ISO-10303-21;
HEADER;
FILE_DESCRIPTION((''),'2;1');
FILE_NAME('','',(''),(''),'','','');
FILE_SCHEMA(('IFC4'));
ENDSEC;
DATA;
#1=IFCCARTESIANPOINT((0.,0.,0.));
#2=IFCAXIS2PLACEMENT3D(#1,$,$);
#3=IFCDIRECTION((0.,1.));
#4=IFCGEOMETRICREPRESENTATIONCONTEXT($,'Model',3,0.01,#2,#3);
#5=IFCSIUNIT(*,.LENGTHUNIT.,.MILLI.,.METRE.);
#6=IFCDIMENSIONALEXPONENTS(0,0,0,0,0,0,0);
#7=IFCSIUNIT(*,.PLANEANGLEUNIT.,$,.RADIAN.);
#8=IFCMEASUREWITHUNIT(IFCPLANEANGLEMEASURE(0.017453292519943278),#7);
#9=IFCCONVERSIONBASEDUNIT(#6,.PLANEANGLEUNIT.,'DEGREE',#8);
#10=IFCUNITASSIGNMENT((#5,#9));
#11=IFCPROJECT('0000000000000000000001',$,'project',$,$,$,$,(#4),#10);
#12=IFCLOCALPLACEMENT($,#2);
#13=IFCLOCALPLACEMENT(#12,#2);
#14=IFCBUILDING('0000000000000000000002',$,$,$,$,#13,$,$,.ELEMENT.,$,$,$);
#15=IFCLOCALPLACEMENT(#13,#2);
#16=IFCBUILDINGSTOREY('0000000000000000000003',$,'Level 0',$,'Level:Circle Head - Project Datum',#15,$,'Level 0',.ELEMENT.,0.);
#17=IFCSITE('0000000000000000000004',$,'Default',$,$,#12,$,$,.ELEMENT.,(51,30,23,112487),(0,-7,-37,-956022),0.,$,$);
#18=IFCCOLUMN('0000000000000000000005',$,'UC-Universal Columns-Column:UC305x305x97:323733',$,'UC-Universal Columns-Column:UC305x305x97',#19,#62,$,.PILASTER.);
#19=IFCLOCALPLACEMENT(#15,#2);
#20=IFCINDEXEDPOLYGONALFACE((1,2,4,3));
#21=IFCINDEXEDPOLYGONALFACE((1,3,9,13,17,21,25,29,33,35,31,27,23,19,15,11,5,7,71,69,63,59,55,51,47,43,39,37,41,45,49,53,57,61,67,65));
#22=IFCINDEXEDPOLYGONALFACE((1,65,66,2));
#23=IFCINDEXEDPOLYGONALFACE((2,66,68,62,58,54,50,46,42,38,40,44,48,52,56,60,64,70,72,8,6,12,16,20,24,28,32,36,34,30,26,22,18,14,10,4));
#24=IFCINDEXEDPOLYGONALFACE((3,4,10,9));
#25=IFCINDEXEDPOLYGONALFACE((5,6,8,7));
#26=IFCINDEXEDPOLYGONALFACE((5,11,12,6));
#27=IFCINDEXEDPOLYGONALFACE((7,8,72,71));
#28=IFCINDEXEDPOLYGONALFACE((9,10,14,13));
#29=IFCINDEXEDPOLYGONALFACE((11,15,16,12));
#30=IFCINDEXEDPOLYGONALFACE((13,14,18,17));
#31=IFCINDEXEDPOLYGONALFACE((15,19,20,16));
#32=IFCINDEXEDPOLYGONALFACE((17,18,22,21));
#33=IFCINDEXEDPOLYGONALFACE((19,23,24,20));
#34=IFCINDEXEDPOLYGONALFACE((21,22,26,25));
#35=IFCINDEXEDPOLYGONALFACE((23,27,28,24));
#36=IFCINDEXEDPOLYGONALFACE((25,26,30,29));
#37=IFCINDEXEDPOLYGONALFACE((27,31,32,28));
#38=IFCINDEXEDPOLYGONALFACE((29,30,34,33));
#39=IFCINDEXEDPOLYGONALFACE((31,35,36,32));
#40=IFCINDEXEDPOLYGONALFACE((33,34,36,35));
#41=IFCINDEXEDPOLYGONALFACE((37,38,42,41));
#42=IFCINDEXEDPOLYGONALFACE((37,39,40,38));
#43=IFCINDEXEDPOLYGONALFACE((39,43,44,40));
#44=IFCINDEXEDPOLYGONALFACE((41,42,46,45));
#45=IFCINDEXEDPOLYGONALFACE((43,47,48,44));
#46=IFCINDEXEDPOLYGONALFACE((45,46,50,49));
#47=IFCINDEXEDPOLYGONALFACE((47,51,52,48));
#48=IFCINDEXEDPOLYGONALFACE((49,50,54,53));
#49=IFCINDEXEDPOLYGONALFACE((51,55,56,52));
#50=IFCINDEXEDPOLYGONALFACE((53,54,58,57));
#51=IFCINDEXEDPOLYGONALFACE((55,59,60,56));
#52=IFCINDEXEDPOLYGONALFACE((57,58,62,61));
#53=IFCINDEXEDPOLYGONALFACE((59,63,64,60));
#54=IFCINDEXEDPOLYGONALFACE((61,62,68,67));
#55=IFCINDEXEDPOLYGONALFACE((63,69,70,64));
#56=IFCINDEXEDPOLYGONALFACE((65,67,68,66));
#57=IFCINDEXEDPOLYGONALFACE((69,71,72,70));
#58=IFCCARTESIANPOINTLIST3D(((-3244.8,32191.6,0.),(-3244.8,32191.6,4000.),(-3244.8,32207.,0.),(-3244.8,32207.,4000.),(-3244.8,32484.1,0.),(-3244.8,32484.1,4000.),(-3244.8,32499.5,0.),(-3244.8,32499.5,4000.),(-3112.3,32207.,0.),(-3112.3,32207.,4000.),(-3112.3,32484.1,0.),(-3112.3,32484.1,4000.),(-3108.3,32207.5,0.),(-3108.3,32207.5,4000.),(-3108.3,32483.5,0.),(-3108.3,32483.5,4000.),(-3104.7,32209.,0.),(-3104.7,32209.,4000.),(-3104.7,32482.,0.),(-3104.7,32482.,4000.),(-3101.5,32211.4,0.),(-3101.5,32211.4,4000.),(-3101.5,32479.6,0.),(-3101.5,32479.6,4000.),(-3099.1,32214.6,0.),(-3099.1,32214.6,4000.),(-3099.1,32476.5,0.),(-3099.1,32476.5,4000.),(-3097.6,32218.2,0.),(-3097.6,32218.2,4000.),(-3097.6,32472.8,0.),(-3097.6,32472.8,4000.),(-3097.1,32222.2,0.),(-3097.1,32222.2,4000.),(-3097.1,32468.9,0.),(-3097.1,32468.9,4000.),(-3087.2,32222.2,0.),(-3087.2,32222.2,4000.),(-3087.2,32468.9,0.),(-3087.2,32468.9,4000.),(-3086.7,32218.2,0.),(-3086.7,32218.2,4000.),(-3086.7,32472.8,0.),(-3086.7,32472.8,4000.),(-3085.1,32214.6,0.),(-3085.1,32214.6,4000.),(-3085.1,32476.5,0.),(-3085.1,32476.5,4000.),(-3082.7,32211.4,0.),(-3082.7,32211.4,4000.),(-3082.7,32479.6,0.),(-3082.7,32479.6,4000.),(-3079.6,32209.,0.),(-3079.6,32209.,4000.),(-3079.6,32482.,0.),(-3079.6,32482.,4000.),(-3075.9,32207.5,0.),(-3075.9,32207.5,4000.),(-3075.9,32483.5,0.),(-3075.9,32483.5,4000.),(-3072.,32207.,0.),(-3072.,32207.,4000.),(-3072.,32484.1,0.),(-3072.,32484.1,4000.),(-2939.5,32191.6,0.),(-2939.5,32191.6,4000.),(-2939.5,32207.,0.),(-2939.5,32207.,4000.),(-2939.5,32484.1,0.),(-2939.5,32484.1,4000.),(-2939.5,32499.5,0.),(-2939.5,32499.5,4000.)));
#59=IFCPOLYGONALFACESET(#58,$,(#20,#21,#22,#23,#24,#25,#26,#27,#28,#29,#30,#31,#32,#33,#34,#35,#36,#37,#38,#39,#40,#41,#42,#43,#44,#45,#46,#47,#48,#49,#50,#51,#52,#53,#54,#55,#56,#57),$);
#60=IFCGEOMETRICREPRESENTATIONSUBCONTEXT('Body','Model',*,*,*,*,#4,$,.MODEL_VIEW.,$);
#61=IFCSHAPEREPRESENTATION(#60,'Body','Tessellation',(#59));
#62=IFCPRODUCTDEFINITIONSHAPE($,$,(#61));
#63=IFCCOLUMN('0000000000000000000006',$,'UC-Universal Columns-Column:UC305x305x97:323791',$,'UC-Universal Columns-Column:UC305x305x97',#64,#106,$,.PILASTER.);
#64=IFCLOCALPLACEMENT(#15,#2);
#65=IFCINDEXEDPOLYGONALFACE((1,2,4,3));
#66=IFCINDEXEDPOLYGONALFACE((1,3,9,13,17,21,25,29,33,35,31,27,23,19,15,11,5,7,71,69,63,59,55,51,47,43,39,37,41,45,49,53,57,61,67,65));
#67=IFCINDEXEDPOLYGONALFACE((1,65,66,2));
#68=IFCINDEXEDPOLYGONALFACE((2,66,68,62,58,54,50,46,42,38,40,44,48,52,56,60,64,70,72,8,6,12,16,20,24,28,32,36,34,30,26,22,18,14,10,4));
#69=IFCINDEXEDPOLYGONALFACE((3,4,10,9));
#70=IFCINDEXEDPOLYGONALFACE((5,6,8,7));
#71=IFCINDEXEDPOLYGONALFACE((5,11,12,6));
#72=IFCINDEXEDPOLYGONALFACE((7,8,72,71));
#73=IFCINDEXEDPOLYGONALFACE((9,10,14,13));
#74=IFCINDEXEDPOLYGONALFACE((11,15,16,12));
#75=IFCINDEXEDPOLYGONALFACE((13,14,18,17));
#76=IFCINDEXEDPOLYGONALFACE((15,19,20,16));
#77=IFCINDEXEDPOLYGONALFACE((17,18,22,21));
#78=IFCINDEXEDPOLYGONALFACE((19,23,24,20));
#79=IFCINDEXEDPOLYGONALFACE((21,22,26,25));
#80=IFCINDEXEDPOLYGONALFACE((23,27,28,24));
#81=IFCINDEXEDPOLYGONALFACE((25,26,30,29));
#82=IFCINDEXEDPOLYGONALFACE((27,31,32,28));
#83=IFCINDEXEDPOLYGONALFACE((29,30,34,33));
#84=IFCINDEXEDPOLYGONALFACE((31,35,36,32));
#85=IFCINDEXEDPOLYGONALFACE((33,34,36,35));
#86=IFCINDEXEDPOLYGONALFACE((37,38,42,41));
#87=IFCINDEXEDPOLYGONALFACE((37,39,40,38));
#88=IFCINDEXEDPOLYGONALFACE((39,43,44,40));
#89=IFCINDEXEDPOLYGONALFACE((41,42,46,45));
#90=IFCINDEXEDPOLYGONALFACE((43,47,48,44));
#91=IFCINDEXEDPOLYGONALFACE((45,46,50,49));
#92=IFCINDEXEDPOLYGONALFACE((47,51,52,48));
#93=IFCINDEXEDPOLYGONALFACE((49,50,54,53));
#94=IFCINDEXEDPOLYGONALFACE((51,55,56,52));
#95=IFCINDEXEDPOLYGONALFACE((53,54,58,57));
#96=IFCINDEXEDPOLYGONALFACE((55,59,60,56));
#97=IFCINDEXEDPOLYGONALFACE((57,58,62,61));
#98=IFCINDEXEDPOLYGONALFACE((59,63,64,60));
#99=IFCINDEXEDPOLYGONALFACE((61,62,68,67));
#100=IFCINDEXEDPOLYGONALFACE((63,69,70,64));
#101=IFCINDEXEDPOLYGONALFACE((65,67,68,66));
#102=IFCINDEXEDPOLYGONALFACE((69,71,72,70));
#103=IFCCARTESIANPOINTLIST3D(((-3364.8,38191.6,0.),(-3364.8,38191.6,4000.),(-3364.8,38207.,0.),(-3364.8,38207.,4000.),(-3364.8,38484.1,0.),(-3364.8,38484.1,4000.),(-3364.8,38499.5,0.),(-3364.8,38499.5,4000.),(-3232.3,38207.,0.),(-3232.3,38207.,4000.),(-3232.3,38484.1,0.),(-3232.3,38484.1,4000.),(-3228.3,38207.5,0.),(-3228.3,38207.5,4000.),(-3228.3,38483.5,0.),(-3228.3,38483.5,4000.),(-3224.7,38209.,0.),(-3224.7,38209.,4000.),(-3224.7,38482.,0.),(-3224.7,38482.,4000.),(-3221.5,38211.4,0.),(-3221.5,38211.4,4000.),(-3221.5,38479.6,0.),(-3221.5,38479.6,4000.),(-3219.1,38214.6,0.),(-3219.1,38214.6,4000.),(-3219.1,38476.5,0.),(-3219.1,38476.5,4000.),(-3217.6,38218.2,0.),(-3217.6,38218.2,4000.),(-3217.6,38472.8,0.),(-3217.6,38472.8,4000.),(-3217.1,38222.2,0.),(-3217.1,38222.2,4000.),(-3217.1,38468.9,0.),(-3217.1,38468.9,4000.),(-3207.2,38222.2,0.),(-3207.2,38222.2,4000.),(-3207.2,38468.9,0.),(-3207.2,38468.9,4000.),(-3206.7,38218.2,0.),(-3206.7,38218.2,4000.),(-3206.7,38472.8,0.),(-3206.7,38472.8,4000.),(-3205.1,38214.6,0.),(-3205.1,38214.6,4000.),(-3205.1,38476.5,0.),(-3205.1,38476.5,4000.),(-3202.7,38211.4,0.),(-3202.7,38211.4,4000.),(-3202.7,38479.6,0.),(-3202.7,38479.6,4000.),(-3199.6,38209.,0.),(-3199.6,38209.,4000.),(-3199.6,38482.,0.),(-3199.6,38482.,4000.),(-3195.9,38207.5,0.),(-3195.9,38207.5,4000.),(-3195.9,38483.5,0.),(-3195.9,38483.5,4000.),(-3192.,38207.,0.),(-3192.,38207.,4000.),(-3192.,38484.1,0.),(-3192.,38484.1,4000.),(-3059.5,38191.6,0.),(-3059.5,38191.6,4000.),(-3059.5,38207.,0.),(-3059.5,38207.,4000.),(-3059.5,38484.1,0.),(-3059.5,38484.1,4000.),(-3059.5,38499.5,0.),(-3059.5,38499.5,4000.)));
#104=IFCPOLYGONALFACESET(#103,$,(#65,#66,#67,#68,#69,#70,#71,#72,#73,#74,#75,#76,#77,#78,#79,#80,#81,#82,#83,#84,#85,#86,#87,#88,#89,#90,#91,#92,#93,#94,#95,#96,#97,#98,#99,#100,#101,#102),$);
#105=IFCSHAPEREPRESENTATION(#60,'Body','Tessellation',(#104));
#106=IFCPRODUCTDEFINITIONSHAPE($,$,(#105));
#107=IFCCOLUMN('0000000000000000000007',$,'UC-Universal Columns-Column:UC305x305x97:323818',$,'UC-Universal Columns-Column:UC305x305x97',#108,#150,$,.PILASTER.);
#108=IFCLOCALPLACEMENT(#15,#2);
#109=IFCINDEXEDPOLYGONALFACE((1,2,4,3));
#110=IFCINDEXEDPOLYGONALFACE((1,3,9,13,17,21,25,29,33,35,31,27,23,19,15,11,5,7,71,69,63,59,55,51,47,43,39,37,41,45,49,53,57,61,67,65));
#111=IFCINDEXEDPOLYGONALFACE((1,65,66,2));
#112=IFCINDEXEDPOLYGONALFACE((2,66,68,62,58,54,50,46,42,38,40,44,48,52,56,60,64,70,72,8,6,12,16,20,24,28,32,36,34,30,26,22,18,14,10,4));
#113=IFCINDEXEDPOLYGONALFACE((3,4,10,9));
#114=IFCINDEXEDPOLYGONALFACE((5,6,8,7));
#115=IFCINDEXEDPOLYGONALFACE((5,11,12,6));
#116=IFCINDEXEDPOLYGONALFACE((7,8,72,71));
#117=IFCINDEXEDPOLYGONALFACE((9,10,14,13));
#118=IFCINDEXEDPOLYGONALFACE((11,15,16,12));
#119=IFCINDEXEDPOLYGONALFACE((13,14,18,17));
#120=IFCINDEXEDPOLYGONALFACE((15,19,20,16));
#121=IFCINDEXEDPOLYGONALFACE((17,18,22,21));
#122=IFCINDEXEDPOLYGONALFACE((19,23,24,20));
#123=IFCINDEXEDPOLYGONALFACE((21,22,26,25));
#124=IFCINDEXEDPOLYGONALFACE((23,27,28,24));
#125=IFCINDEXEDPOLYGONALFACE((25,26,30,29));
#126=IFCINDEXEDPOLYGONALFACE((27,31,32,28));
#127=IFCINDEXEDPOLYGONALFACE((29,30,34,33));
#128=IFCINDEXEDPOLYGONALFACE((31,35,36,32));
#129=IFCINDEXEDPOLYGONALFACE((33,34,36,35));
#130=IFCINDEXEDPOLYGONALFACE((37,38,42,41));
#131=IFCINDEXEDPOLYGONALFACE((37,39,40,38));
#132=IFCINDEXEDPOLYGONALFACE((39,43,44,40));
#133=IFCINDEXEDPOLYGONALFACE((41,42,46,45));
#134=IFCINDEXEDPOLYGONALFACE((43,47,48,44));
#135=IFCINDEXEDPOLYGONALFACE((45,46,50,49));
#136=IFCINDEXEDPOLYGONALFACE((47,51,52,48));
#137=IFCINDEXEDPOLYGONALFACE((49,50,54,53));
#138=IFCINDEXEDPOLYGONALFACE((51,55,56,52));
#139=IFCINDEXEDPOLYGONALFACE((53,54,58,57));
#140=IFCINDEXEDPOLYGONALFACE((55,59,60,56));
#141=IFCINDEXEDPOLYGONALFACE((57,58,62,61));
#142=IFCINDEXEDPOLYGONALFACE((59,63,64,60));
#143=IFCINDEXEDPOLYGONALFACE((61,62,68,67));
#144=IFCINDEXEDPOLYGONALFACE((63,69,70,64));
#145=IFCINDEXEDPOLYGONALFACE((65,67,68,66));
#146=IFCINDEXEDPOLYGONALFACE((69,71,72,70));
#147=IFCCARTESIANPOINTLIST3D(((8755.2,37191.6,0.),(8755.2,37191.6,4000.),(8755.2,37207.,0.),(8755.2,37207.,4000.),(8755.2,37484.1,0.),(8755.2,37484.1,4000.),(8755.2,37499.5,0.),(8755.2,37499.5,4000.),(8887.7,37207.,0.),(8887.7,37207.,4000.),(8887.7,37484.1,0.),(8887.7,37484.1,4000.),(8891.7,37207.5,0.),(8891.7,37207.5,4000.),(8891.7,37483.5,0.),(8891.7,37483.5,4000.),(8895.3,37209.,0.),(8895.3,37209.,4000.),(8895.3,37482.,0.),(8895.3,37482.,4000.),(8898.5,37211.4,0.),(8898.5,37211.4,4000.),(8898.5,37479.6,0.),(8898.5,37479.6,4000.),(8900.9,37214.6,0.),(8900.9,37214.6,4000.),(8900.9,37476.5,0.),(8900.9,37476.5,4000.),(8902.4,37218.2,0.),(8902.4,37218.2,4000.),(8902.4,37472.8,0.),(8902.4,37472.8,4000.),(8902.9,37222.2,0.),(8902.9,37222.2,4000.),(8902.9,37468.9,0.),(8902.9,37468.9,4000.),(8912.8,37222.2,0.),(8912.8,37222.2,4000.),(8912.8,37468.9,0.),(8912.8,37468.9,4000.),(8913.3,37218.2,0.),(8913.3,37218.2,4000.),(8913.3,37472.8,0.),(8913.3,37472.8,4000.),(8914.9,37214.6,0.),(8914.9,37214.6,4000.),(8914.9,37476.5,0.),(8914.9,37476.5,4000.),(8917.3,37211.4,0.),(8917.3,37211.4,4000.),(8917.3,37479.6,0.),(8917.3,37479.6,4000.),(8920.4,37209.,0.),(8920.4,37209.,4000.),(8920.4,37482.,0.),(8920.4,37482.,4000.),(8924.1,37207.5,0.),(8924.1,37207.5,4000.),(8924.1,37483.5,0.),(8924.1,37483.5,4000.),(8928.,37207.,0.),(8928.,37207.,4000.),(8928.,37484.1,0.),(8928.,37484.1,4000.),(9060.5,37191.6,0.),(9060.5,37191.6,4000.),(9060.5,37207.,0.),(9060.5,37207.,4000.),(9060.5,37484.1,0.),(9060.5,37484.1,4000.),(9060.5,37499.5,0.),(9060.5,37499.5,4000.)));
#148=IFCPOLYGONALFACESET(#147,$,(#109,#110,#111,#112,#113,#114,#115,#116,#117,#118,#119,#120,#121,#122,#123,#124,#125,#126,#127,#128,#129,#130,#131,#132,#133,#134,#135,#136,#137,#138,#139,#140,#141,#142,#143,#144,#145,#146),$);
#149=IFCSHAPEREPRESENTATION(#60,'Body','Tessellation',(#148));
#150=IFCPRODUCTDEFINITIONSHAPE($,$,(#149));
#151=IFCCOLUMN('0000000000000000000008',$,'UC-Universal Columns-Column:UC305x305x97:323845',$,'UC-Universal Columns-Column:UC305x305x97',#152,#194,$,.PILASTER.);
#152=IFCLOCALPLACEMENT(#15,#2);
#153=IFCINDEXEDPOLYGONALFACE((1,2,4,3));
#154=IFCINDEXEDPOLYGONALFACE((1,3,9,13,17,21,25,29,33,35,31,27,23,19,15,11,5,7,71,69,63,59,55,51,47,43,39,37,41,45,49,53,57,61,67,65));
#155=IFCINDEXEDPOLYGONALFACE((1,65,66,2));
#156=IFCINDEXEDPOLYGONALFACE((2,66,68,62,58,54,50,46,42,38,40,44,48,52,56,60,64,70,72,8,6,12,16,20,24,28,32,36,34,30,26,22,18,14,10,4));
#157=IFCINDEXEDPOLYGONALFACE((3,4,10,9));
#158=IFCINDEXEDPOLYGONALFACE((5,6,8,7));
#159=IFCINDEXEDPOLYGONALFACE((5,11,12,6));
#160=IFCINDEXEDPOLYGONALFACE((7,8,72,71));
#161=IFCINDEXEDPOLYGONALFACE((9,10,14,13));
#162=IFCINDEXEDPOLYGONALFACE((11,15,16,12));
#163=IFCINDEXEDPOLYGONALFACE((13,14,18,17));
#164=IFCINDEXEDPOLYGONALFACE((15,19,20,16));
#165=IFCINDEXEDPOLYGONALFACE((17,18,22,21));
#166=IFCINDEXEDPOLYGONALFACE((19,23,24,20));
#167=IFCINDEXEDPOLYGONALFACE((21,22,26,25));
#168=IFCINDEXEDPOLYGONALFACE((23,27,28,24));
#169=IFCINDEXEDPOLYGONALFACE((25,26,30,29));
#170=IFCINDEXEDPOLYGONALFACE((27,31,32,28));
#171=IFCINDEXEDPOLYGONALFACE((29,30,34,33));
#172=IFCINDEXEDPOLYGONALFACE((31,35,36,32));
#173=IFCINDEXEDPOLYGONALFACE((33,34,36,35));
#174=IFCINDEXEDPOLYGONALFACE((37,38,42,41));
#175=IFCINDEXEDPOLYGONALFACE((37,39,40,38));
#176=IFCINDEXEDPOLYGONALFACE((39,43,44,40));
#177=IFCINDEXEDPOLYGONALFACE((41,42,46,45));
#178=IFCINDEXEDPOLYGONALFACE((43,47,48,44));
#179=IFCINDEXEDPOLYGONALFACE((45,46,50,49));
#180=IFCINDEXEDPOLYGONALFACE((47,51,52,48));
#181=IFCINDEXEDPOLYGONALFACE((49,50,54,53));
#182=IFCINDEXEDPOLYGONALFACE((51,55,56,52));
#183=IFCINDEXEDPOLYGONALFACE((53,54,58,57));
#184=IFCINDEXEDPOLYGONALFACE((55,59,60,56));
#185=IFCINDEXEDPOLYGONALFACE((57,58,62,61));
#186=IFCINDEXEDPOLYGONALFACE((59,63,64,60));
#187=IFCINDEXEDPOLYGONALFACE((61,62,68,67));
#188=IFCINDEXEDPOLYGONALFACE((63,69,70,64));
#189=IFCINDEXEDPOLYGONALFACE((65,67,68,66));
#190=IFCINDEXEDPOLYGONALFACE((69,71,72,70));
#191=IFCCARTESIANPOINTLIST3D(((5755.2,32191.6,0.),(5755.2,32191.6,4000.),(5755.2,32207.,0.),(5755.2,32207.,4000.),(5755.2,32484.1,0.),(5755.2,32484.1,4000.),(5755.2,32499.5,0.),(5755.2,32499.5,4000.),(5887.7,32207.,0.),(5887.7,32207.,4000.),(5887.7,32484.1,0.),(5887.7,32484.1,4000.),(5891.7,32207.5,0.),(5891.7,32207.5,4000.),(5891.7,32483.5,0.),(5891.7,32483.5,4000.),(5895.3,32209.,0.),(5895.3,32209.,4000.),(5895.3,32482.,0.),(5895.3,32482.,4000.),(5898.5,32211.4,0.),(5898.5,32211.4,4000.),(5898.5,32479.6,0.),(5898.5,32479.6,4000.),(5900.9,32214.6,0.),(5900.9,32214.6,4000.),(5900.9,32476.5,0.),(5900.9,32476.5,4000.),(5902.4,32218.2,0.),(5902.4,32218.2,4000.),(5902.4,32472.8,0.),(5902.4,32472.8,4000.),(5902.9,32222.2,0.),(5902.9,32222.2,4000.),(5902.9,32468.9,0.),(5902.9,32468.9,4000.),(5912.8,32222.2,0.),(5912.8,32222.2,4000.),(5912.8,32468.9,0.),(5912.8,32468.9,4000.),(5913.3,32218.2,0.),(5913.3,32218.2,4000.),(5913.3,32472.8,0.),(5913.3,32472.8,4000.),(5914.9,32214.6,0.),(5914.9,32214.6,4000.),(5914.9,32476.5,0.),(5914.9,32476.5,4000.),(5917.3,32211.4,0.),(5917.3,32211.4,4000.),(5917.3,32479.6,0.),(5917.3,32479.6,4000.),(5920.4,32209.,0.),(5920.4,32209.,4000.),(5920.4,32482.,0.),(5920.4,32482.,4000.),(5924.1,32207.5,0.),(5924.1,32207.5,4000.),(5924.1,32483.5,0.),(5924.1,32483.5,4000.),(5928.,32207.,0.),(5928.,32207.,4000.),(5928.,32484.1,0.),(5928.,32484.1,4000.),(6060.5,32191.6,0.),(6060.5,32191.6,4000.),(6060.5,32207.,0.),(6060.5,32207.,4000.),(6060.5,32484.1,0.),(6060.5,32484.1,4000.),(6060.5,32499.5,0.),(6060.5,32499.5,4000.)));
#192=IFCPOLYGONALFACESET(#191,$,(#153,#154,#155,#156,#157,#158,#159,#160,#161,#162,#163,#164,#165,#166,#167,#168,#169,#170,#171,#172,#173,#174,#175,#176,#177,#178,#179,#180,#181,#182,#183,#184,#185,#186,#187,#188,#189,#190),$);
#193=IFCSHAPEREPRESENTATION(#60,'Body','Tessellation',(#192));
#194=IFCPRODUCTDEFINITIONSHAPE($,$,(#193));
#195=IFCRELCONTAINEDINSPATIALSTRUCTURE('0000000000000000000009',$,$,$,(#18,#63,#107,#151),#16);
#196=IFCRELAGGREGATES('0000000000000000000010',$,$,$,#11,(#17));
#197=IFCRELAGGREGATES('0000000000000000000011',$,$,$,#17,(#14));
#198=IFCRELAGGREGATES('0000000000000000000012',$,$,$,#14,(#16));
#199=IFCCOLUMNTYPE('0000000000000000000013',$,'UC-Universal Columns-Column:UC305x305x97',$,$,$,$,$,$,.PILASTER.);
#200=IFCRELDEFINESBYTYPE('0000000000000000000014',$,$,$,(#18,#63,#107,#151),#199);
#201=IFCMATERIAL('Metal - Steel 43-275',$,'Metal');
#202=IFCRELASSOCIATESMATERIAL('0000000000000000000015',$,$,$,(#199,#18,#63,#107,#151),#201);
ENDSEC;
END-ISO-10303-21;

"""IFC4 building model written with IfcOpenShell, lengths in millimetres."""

from ifc_helpers import new_model, entity, si_unit, converted_unit, direction, frame, origin, place, context, subcontext, project, spatial, line, arc, indexed_curve, outline, extrude, source, transform, mapped, material, type_object, type_shapes, element, save


model = new_model("IFC4")

# Units and contexts
model_context = context("Model", 3, precision=0.01, world=origin(), true_north=direction((0.0, 1.0)))
body_context = subcontext(model_context, "Body", "Model", "MODEL_VIEW")
ifc_project = project(units=[si_unit("LENGTHUNIT", "METRE", prefix="MILLI"), converted_unit("PLANEANGLEUNIT", "DEGREE", entity("IfcPlaneAngleMeasure", 0.017453292519943278), si_unit("PLANEANGLEUNIT", "RADIAN"), dimensions=[0, 0, 0, 0, 0, 0, 0])], contexts=[model_context])

# Site, building, storey
site_placement = place(None, origin())
site = spatial("IfcSite", under=ifc_project, at=site_placement, Name="Default", CompositionType="ELEMENT", RefLatitude=(51, 30, 23, 112487), RefLongitude=(0, -7, -37, -956022), RefElevation=0.0)
building_placement = place(site_placement, origin())
building = spatial("IfcBuilding", under=site, at=building_placement, CompositionType="ELEMENT")
storey_placement = place(building_placement, origin())
storey = spatial("IfcBuildingStorey", under=building, at=storey_placement, Name="Level 0", ObjectType="Level:Circle Head - Project Datum", LongName="Level 0", CompositionType="ELEMENT", Elevation=0.0)

# Columns
ifc_material_1 = material(Name="Metal - Steel 43-275", Category="Metal")
column_type = type_object("IfcColumnType", Name="UC-Universal Columns-Column:UC305x305x97", PredefinedType="PILASTER", material=ifc_material_1)
shared_shape_1 = source(origin(), body_context, "Body", "SweptSolid", [
    extrude(outline(indexed_curve([(-152.6, -153.9), (152.6, -153.9), (152.6, -138.5), (20.2, -138.5), (9.4, -134.1), (4.9, -123.4), (4.9, 123.3), (9.4, 134.1), (20.1, 138.5), (152.6, 138.5), (152.6, 153.9), (-152.6, 153.9), (-152.6, 138.5), (-20.2, 138.6), (-9.4, 134.1), (-5.0, 123.4), (-5.0, -123.3), (-9.4, -134.1), (-20.2, -138.5), (-152.6, -138.5)], segments=[line(1, 2, 3, 4), arc(4, 5, 6), line(6, 7), arc(7, 8, 9), line(9, 10, 11, 12, 13, 14), arc(14, 15, 16), line(16, 17), arc(17, 18, 19), line(19, 20, 1)], self_intersect=False)), frame((0.0, 0.0, 0.0), z_axis=(0.0, 0.0, 1.0), x_axis=(-1.0, 0.0, 0.0)), (0.0, 0.0, 1.0), 4000.0),
])
type_shapes(column_type, [shared_shape_1])
for number, where, name in (
    (1, (-3092.1, 32345.5, 0.0), "UC-Universal Columns-Column:UC305x305x97:323733"),
    (2, (-3212.1, 38345.5, 0.0), "UC-Universal Columns-Column:UC305x305x97:323791"),
    (3, (8907.9, 37345.5, 0.0), "UC-Universal Columns-Column:UC305x305x97:323818"),
    (4, (5907.9, 32345.5, 0.0), "UC-Universal Columns-Column:UC305x305x97:323845"),
):
    element("IfcColumn", number, at=place(storey_placement, frame(where)), inside=storey, type_object=column_type, material=ifc_material_1, Name=name, ObjectType="UC-Universal Columns-Column:UC305x305x97", PredefinedType="PILASTER", context=body_context, shape_type="MappedRepresentation", body=[
        mapped(shared_shape_1, transform((0.0, 0.0, 0.0), scale=1.0)),
    ])

save(model, "model.ifc")
